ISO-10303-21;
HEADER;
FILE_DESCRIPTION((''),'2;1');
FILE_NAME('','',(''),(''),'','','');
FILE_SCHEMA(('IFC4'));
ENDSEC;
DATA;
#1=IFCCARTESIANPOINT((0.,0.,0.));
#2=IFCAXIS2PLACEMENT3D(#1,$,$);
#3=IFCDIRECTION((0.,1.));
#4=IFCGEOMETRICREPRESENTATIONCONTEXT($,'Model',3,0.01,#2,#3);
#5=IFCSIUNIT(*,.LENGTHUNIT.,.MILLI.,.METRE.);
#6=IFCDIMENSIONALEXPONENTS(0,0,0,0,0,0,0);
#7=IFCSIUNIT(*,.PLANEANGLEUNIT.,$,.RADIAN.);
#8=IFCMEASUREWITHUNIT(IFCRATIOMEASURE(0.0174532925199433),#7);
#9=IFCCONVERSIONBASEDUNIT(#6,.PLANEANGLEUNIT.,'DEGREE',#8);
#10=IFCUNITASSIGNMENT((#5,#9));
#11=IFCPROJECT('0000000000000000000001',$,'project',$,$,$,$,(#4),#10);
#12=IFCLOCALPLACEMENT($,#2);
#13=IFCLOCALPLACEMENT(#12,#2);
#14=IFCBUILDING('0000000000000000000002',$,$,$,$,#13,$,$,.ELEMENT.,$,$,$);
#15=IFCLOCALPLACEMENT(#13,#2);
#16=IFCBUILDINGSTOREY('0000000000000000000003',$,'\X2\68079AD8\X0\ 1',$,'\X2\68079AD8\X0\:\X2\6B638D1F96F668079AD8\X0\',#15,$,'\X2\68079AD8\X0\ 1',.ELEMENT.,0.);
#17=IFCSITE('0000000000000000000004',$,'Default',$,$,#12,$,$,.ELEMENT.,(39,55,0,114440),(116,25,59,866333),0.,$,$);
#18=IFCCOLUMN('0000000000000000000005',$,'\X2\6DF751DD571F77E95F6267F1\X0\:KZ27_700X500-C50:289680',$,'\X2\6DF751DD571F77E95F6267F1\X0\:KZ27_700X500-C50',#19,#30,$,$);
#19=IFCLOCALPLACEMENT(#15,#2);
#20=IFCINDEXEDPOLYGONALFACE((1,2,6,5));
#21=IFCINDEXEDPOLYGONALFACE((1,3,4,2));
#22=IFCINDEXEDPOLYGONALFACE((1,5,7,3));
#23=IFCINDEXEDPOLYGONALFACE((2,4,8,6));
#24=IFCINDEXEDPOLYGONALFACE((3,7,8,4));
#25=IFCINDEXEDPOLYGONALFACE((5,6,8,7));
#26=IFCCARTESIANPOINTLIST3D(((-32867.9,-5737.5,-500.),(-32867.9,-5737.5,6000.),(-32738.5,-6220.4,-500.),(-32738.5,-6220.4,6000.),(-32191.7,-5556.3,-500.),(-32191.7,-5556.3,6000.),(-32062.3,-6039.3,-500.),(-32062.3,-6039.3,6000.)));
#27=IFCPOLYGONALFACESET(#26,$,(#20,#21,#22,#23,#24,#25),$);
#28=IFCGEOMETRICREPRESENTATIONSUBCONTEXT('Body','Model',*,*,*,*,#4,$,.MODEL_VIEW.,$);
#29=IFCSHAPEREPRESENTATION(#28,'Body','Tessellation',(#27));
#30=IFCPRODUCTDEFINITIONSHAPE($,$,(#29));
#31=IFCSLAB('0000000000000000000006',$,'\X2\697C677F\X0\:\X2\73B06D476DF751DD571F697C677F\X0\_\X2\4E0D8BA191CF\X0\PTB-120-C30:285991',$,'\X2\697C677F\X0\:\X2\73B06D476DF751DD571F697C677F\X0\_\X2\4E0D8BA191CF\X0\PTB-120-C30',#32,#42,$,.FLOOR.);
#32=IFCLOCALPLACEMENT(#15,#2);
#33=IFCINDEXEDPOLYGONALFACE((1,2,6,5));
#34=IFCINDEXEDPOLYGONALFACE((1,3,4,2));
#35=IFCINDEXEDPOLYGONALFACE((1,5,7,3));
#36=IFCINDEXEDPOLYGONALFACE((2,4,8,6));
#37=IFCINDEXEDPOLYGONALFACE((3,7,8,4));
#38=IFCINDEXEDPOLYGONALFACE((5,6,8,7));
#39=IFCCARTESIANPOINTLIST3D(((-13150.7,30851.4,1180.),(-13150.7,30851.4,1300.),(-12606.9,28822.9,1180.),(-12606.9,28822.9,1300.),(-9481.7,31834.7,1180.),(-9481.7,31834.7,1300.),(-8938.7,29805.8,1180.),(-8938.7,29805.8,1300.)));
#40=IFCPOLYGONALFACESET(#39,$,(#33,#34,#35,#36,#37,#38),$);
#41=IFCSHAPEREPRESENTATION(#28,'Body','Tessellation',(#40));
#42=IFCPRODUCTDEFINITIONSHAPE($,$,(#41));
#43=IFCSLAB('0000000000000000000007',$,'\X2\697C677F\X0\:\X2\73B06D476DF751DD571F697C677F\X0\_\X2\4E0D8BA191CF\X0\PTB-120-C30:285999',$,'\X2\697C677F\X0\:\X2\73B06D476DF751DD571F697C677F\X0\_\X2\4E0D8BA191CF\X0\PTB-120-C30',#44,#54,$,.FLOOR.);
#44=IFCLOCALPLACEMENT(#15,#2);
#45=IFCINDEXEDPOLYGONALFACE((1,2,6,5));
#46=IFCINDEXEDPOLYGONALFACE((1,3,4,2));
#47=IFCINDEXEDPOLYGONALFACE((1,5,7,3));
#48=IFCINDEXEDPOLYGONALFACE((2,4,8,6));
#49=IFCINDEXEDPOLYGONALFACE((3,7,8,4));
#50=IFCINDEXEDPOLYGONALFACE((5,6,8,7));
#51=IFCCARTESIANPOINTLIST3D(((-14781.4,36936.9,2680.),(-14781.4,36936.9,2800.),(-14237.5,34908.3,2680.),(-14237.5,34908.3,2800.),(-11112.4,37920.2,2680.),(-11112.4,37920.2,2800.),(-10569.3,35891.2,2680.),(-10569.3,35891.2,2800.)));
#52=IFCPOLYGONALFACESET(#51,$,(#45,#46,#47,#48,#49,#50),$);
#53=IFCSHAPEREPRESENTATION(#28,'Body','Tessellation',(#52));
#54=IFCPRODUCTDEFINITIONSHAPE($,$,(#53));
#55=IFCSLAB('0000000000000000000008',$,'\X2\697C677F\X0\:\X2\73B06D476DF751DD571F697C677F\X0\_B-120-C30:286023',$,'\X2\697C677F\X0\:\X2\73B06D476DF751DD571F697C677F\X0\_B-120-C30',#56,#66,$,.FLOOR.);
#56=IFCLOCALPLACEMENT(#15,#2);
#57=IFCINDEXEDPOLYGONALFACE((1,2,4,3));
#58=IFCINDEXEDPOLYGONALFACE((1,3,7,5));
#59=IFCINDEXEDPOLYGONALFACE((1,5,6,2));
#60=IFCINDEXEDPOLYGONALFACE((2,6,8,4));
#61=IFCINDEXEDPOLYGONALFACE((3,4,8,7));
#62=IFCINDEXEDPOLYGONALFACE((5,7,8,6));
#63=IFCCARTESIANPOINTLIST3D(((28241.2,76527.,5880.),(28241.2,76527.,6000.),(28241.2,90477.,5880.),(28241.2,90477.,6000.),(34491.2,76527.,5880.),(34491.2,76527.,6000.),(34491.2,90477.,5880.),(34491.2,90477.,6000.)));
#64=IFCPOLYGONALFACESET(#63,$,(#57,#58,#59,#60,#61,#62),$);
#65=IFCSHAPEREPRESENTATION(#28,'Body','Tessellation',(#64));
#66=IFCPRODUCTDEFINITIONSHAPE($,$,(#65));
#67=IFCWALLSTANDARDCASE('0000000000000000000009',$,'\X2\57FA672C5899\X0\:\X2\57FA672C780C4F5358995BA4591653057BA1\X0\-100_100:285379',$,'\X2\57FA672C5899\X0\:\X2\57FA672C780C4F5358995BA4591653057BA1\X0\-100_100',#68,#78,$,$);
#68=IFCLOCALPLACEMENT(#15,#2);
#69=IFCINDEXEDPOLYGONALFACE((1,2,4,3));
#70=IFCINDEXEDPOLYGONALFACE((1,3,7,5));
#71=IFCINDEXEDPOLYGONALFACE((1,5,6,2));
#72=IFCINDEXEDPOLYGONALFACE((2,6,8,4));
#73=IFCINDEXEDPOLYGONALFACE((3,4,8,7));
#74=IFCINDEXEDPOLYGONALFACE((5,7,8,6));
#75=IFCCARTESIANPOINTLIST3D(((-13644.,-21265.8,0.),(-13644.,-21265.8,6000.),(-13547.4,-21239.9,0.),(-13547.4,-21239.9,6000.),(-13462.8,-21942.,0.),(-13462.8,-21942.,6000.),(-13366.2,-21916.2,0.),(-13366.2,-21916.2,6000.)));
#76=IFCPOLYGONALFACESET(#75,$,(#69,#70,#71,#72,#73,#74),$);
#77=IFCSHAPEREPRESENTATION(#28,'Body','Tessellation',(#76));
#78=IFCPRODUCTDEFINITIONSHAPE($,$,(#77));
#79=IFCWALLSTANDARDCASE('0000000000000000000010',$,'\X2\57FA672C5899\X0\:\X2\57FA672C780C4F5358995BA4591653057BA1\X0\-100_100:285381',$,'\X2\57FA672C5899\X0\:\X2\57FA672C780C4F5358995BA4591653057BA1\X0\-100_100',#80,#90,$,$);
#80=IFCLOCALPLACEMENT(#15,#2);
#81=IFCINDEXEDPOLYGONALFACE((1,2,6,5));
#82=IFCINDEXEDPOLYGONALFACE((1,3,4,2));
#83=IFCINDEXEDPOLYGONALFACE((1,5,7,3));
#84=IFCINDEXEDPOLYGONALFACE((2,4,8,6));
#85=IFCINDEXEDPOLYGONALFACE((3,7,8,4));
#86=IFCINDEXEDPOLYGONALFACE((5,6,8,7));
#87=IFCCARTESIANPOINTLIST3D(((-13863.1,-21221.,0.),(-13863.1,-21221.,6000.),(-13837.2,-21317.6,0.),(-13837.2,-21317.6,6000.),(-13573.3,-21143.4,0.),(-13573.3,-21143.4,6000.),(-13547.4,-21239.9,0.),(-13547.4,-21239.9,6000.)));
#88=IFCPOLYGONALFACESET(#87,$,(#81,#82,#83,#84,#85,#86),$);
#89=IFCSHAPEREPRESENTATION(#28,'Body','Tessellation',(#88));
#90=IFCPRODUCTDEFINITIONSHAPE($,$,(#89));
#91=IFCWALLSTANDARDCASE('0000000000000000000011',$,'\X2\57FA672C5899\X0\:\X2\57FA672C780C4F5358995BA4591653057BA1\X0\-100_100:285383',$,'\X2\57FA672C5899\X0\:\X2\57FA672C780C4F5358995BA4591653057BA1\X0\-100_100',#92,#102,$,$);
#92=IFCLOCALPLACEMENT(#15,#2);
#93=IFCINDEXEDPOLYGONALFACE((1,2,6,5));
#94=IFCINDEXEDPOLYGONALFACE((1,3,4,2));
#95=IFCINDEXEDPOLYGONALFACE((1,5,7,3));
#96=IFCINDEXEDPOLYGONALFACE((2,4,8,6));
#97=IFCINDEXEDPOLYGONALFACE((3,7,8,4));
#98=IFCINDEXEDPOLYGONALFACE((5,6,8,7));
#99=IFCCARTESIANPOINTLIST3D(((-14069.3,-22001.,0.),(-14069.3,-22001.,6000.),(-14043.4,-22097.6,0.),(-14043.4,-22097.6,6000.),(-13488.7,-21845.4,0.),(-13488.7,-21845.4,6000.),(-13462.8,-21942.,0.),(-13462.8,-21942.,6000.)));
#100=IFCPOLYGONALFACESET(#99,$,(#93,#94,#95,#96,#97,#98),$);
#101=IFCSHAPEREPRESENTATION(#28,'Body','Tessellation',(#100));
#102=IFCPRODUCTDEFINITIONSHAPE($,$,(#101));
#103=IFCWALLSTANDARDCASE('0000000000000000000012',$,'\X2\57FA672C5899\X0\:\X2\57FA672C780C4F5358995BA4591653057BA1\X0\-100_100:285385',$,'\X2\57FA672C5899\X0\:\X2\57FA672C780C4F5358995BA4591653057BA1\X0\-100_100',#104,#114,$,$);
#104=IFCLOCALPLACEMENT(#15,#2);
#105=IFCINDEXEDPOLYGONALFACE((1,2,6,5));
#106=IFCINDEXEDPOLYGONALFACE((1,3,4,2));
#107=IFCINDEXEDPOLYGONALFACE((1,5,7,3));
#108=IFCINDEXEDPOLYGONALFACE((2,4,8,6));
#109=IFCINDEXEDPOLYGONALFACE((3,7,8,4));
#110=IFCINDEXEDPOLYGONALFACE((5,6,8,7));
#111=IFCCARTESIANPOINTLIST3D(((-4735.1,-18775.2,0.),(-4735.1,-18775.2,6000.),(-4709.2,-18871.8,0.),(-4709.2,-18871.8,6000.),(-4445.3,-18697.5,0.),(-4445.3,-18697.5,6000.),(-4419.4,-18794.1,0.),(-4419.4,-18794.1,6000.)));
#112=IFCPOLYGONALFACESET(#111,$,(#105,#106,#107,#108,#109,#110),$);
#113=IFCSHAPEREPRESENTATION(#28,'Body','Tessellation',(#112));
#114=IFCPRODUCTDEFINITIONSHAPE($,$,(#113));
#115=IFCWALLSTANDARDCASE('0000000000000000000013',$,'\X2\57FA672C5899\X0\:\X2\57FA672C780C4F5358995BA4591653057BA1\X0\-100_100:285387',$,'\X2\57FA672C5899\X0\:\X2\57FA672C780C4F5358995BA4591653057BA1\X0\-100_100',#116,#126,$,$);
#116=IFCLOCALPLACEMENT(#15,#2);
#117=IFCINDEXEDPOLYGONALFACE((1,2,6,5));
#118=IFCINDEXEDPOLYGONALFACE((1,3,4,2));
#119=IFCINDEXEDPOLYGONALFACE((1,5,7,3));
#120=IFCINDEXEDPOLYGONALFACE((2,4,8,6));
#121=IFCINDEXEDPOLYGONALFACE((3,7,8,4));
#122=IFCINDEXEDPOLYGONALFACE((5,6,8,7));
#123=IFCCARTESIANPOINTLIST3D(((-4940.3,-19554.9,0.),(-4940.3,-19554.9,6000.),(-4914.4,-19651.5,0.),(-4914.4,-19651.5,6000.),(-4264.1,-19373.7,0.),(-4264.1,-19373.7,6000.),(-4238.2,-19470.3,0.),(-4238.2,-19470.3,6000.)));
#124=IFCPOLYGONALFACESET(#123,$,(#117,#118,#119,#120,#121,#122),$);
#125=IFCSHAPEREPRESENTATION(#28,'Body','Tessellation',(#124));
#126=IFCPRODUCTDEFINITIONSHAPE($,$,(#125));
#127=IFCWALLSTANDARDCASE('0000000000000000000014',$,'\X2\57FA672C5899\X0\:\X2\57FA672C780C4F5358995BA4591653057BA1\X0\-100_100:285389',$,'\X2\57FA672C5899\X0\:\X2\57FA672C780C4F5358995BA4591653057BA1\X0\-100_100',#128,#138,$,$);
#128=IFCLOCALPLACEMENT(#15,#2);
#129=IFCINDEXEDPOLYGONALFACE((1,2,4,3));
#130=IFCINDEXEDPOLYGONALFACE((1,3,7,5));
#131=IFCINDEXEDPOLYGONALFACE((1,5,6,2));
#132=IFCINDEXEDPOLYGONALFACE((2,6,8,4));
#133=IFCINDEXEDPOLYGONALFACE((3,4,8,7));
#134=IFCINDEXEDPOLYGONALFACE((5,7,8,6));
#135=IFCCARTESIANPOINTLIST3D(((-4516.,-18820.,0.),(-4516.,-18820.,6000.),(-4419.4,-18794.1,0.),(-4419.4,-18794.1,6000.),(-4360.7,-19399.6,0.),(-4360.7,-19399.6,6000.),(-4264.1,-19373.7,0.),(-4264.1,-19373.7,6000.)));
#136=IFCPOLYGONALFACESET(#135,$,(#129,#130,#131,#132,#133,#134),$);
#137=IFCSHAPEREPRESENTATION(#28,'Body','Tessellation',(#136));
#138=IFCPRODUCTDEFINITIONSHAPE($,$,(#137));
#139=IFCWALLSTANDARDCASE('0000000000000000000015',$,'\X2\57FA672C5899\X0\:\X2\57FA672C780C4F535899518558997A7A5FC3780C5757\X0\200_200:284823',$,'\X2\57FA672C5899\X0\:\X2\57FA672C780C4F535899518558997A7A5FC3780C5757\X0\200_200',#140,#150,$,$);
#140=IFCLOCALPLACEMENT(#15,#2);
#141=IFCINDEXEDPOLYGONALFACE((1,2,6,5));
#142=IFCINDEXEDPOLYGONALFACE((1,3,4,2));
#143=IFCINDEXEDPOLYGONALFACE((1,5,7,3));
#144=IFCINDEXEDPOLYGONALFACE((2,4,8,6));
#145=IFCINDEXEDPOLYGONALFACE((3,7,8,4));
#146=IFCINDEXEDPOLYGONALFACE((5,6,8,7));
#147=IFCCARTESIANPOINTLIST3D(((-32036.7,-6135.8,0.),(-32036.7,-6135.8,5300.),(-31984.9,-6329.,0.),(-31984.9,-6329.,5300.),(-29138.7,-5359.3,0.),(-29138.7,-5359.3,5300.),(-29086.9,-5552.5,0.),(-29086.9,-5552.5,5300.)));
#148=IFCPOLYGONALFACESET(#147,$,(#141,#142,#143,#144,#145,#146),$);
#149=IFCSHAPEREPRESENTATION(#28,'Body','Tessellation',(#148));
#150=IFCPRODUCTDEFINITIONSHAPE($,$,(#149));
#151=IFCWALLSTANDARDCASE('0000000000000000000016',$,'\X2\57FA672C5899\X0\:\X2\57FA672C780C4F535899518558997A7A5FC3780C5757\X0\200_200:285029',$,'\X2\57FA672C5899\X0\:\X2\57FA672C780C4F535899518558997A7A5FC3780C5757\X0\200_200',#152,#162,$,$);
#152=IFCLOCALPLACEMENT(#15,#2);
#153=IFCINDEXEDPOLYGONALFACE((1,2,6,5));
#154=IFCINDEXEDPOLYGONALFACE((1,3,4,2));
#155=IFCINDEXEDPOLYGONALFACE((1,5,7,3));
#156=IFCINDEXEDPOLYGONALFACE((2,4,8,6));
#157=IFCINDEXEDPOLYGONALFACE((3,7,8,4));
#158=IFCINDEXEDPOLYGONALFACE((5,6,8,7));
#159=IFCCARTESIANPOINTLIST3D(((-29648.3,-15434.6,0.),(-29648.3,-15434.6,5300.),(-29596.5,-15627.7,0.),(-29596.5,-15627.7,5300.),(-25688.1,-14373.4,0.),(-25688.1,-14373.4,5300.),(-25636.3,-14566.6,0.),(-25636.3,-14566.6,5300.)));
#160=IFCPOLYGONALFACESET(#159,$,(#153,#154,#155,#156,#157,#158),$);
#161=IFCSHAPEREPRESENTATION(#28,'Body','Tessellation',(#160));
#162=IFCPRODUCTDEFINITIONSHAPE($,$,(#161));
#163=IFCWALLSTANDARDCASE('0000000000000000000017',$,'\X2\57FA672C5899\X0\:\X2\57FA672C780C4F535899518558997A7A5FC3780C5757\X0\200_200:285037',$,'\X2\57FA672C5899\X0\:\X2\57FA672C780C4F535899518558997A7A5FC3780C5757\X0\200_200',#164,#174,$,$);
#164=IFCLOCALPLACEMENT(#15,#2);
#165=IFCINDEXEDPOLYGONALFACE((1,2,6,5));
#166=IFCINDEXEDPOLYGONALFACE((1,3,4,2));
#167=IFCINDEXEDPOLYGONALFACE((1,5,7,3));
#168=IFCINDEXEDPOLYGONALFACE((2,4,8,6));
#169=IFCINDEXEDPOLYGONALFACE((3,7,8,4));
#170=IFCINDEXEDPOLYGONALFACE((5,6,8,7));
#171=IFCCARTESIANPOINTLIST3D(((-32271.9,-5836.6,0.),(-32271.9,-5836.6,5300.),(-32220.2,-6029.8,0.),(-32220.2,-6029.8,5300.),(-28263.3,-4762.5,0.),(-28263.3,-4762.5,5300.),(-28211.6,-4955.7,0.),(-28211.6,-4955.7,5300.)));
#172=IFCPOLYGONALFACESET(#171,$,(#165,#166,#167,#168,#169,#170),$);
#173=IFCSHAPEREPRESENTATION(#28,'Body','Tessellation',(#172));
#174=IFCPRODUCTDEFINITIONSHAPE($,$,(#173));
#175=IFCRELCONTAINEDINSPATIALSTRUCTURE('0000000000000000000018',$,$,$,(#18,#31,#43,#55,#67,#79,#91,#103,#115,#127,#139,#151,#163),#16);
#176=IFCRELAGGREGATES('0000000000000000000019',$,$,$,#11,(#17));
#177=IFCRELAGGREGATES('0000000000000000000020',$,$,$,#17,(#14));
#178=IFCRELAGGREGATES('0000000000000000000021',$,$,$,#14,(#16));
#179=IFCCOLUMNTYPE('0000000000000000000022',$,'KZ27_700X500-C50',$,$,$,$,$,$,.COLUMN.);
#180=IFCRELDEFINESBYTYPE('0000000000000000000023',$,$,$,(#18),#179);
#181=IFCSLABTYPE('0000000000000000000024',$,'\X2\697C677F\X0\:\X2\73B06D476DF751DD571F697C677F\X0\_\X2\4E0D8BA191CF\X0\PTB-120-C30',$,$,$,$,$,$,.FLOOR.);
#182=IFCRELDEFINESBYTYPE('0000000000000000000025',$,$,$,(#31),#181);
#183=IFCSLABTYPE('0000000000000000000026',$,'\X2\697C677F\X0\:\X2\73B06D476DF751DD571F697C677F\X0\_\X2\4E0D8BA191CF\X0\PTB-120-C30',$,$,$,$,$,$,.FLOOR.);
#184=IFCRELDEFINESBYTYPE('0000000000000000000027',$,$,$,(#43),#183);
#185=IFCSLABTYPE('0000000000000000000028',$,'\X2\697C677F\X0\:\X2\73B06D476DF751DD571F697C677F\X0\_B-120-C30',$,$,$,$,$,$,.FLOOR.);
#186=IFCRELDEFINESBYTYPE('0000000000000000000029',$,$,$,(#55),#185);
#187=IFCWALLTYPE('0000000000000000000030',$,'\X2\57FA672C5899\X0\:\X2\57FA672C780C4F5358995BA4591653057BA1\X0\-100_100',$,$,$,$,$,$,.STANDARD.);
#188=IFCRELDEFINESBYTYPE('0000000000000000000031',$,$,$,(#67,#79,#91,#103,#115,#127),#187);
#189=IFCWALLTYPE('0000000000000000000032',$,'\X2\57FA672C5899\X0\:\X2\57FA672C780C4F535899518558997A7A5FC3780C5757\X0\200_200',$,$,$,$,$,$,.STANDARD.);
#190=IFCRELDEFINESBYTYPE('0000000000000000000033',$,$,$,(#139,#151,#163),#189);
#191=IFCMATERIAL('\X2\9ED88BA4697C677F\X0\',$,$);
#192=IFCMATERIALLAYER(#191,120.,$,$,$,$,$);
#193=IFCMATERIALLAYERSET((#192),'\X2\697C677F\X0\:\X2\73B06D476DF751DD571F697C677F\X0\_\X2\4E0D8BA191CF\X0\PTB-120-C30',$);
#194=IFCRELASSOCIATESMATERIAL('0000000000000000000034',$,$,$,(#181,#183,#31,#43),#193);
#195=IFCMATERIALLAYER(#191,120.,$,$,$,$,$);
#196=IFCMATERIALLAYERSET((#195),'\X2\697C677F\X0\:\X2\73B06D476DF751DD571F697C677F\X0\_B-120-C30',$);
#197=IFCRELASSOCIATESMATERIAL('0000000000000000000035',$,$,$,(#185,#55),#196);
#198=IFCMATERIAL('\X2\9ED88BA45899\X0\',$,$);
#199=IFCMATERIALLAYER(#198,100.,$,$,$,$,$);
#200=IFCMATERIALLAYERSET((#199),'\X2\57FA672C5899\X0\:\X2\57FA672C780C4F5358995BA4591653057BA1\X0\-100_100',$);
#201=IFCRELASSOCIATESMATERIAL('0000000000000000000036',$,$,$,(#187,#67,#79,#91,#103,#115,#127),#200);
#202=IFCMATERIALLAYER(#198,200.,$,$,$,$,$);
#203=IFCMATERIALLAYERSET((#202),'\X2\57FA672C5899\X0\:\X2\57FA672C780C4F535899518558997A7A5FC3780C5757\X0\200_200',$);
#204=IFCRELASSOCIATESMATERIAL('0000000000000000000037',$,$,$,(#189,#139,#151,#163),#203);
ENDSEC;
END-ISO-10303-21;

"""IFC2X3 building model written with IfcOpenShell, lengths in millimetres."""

from ifc_helpers import new_model, entity, si_unit, converted_unit, direction, frame, frame_2d, origin, origin_2d_with_axis, place, context, subcontext, project, spatial, polyline, rectangle, outline, extrude, source, transform, mapped, material, layer, layer_set, layer_usage, type_object, type_shapes, element, save


model = new_model("IFC2X3")

# Units and contexts
model_context = context("Model", 3, precision=0.01, world=origin(), true_north=direction((0.0, 1.0)))
body_context = subcontext(model_context, "Body", "Model", "MODEL_VIEW")
ifc_project = project(units=[si_unit("LENGTHUNIT", "METRE", prefix="MILLI"), converted_unit("PLANEANGLEUNIT", "DEGREE", entity("IfcRatioMeasure", 0.0174532925199433), si_unit("PLANEANGLEUNIT", "RADIAN"), dimensions=[0, 0, 0, 0, 0, 0, 0])], contexts=[model_context])

# Site, building, storey
site_placement = place(None, origin())
site = spatial("IfcSite", under=ifc_project, at=site_placement, Name="Default", CompositionType="ELEMENT", RefLatitude=(39, 55, 0, 114440), RefLongitude=(116, 25, 59, 866333), RefElevation=0.0)
building_placement = place(site_placement, origin())
building = spatial("IfcBuilding", under=site, at=building_placement, CompositionType="ELEMENT")
storey_placement = place(building_placement, origin())
storey = spatial("IfcBuildingStorey", under=building, at=storey_placement, Name="标高 1", ObjectType="标高:正负零标高", LongName="标高 1", CompositionType="ELEMENT", Elevation=0.0)

# Column
column_type_1 = type_object("IfcColumnType", Name="KZ27_700X500-C50", PredefinedType="COLUMN")
shared_shape_1 = source(origin(), body_context, "Body", "SweptSolid", [
    extrude(rectangle(XDim=500.0, YDim=700.0, at=origin_2d_with_axis()), frame((0.0, 0.0, -500.0), z_axis=(0.0, 0.0, 1.0), x_axis=(0.0, -1.0, 0.0)), (0.0, 0.0, 1.0), 6500.0),
])
type_shapes(column_type_1, [shared_shape_1])
column_1_placement = place(building_placement, frame((-32465.1, -5888.4, 0.0), z_axis=(0.0, 0.0, 1.0), x_axis=(0.965926, 0.258819, 0.0)))
element("IfcColumn", 1, at=column_1_placement, inside=storey, type_object=column_type_1, Name="混凝土矩形柱:KZ27_700X500-C50:289680", ObjectType="混凝土矩形柱:KZ27_700X500-C50", context=body_context, shape_type="MappedRepresentation", body=[
    mapped(shared_shape_1, transform((0.0, 0.0, 0.0), scale=1.0)),
])

# Slabs
ifc_material_1 = material(Name="默认楼板")
ifc_layer_1 = layer(ifc_material_1, 120.0)
ifc_layer_set_1 = layer_set([ifc_layer_1], Name="楼板:现浇混凝土楼板_不计量PTB-120-C30")
ifc_layer_usage_1 = layer_usage(ifc_layer_set_1, "AXIS3", "POSITIVE", 0.0)
slab_type_1 = type_object("IfcSlabType", Name="楼板:现浇混凝土楼板_不计量PTB-120-C30", PredefinedType="FLOOR", material=ifc_layer_set_1)
slab_1_placement = place(building_placement, origin())
element("IfcSlab", 2, at=slab_1_placement, inside=storey, type_object=slab_type_1, material=ifc_layer_usage_1, Name="楼板:现浇混凝土楼板_不计量PTB-120-C30:285991", ObjectType="楼板:现浇混凝土楼板_不计量PTB-120-C30", PredefinedType="FLOOR", context=body_context, shape_type="SweptSolid", body=[
    extrude(outline(polyline([(-1899.1, -1050.1), (1899.4, -1050.1), (1898.7, 1050.3), (-1899.0, 1050.0), (-1899.1, -1050.1)])), frame((-11044.5, 30328.7, 1300.0), z_axis=(0.0, 0.0, -1.0), x_axis=(0.96591, 0.258877, 0.0)), (0.0, 0.0, 1.0), 120.0),
])
ifc_layer_usage_2 = layer_usage(ifc_layer_set_1, "AXIS3", "POSITIVE", 0.0)
slab_type_2 = type_object("IfcSlabType", Name="楼板:现浇混凝土楼板_不计量PTB-120-C30", PredefinedType="FLOOR", material=ifc_layer_set_1)
slab_2_placement = place(building_placement, origin())
element("IfcSlab", 3, at=slab_2_placement, inside=storey, type_object=slab_type_2, material=ifc_layer_usage_2, Name="楼板:现浇混凝土楼板_不计量PTB-120-C30:285999", ObjectType="楼板:现浇混凝土楼板_不计量PTB-120-C30", PredefinedType="FLOOR", context=body_context, shape_type="SweptSolid", body=[
    extrude(outline(polyline([(-1899.1, -1050.1), (1899.4, -1050.1), (1898.7, 1050.3), (-1899.0, 1050.0), (-1899.1, -1050.1)])), frame((-12675.1, 36414.2, 2800.0), z_axis=(0.0, 0.0, -1.0), x_axis=(0.96591, 0.258877, 0.0)), (0.0, 0.0, 1.0), 120.0),
])
ifc_layer_2 = layer(ifc_material_1, 120.0)
ifc_layer_set_2 = layer_set([ifc_layer_2], Name="楼板:现浇混凝土楼板_B-120-C30")
ifc_layer_usage_3 = layer_usage(ifc_layer_set_2, "AXIS3", "POSITIVE", 0.0)
slab_type_3 = type_object("IfcSlabType", Name="楼板:现浇混凝土楼板_B-120-C30", PredefinedType="FLOOR", material=ifc_layer_set_2)
slab_3_placement = place(building_placement, origin())
element("IfcSlab", 4, at=slab_3_placement, inside=storey, type_object=slab_type_3, material=ifc_layer_usage_3, Name="楼板:现浇混凝土楼板_B-120-C30:286023", ObjectType="楼板:现浇混凝土楼板_B-120-C30", PredefinedType="FLOOR", context=body_context, shape_type="SweptSolid", body=[
    extrude(outline(polyline([(-6975.0, -3125.0), (6975.0, -3125.0), (6975.0, 3125.0), (-6975.0, 3125.0), (-6975.0, -3125.0)])), frame((31366.2, 83502.0, 6000.0), z_axis=(0.0, 0.0, -1.0), x_axis=(0.0, 1.0, 0.0)), (0.0, 0.0, 1.0), 120.0),
])

# Walls
ifc_material_2 = material(Name="默认墙")
ifc_layer_3 = layer(ifc_material_2, 100.0)
ifc_layer_set_3 = layer_set([ifc_layer_3], Name="基本墙:基本砌体墙室外包管-100_100")
ifc_layer_usage_4 = layer_usage(ifc_layer_set_3, "AXIS2", "NEGATIVE", 50.0)
wall_type_1 = type_object("IfcWallType", Name="基本墙:基本砌体墙室外包管-100_100", PredefinedType="STANDARD", material=ifc_layer_set_3)
wall_1_placement = place(building_placement, frame((-13414.5, -21929.1, 0.0), z_axis=(0.0, 0.0, 1.0), x_axis=(-0.258819, 0.965926, 0.0)))
element("IfcWallStandardCase", 5, at=wall_1_placement, inside=storey, type_object=wall_type_1, material=ifc_layer_usage_4, Name="基本墙:基本砌体墙室外包管-100_100:285379", ObjectType="基本墙:基本砌体墙室外包管-100_100", context=body_context, shape_type="SweptSolid", body=[
    extrude(rectangle(XDim=700.1, YDim=100.0, at=frame_2d((350.0, 0.0), x_axis=(-1.0, 0.0))), origin(), (0.0, 0.0, 1.0), 6000.0),
])
ifc_layer_usage_5 = layer_usage(ifc_layer_set_3, "AXIS2", "NEGATIVE", 50.0)
wall_2_placement = place(building_placement, frame((-13560.4, -21191.6, 0.0), z_axis=(0.0, 0.0, 1.0), x_axis=(-0.965926, -0.258819, 0.0)))
element("IfcWallStandardCase", 6, at=wall_2_placement, inside=storey, type_object=wall_type_1, material=ifc_layer_usage_5, Name="基本墙:基本砌体墙室外包管-100_100:285381", ObjectType="基本墙:基本砌体墙室外包管-100_100", context=body_context, shape_type="SweptSolid", body=[
    extrude(rectangle(XDim=300.0, YDim=100.0, at=frame_2d((150.0, 0.0), x_axis=(-1.0, 0.0))), origin(), (0.0, 0.0, 1.0), 6000.0),
])
ifc_layer_usage_6 = layer_usage(ifc_layer_set_3, "AXIS2", "NEGATIVE", 50.0)
wall_3_placement = place(building_placement, frame((-14056.3, -22049.3, 0.0), z_axis=(0.0, 0.0, 1.0), x_axis=(0.965926, 0.258819, 0.0)))
element("IfcWallStandardCase", 7, at=wall_3_placement, inside=storey, type_object=wall_type_1, material=ifc_layer_usage_6, Name="基本墙:基本砌体墙室外包管-100_100:285383", ObjectType="基本墙:基本砌体墙室外包管-100_100", context=body_context, shape_type="SweptSolid", body=[
    extrude(rectangle(XDim=601.0, YDim=100.0, at=frame_2d((300.5, 0.0), x_axis=(-1.0, 0.0))), origin(), (0.0, 0.0, 1.0), 6000.0),
])
ifc_layer_usage_7 = layer_usage(ifc_layer_set_3, "AXIS2", "NEGATIVE", 50.0)
wall_4_placement = place(building_placement, frame((-4432.4, -18745.8, 0.0), z_axis=(0.0, 0.0, 1.0), x_axis=(-0.965926, -0.258819, 0.0)))
element("IfcWallStandardCase", 8, at=wall_4_placement, inside=storey, type_object=wall_type_1, material=ifc_layer_usage_7, Name="基本墙:基本砌体墙室外包管-100_100:285385", ObjectType="基本墙:基本砌体墙室外包管-100_100", context=body_context, shape_type="SweptSolid", body=[
    extrude(rectangle(XDim=300.0, YDim=100.0, at=frame_2d((150.0, 0.0), x_axis=(-1.0, 0.0))), origin(), (0.0, 0.0, 1.0), 6000.0),
])
ifc_layer_usage_8 = layer_usage(ifc_layer_set_3, "AXIS2", "NEGATIVE", 50.0)
wall_5_placement = place(building_placement, frame((-4927.3, -19603.2, 0.0), z_axis=(0.0, 0.0, 1.0), x_axis=(0.965926, 0.258819, 0.0)))
element("IfcWallStandardCase", 9, at=wall_5_placement, inside=storey, type_object=wall_type_1, material=ifc_layer_usage_8, Name="基本墙:基本砌体墙室外包管-100_100:285387", ObjectType="基本墙:基本砌体墙室外包管-100_100", context=body_context, shape_type="SweptSolid", body=[
    extrude(rectangle(XDim=700.0, YDim=100.0, at=frame_2d((350.0, 0.0), x_axis=(-1.0, 0.0))), origin(), (0.0, 0.0, 1.0), 6000.0),
])
ifc_layer_usage_9 = layer_usage(ifc_layer_set_3, "AXIS2", "NEGATIVE", 50.0)
wall_6_placement = place(building_placement, frame((-4312.4, -19386.7, 0.0), z_axis=(0.0, 0.0, 1.0), x_axis=(-0.258819, 0.965926, 0.0)))
element("IfcWallStandardCase", 10, at=wall_6_placement, inside=storey, type_object=wall_type_1, material=ifc_layer_usage_9, Name="基本墙:基本砌体墙室外包管-100_100:285389", ObjectType="基本墙:基本砌体墙室外包管-100_100", context=body_context, shape_type="SweptSolid", body=[
    extrude(rectangle(XDim=600.1, YDim=100.0, at=frame_2d((300.0, 0.0), x_axis=(-1.0, 0.0))), origin(), (0.0, 0.0, 1.0), 6000.0),
])
ifc_layer_4 = layer(ifc_material_2, 200.0)
ifc_layer_set_4 = layer_set([ifc_layer_4], Name="基本墙:基本砌体墙内墙空心砌块200_200")
ifc_layer_usage_10 = layer_usage(ifc_layer_set_4, "AXIS2", "NEGATIVE", 100.0)
wall_type_2 = type_object("IfcWallType", Name="基本墙:基本砌体墙内墙空心砌块200_200", PredefinedType="STANDARD", material=ifc_layer_set_4)
wall_7_placement = place(building_placement, frame((-32010.8, -6232.4, 0.0), z_axis=(0.0, 0.0, 1.0), x_axis=(0.965926, 0.258819, 0.0)))
element("IfcWallStandardCase", 11, at=wall_7_placement, inside=storey, type_object=wall_type_2, material=ifc_layer_usage_10, Name="基本墙:基本砌体墙内墙空心砌块200_200:284823", ObjectType="基本墙:基本砌体墙内墙空心砌块200_200", context=body_context, shape_type="SweptSolid", body=[
    extrude(rectangle(XDim=3000.2, YDim=200.0, at=frame_2d((1500.1, 0.0), x_axis=(-1.0, 0.0))), origin(), (0.0, 0.0, 1.0), 5300.0),
])
ifc_layer_usage_11 = layer_usage(ifc_layer_set_4, "AXIS2", "NEGATIVE", 100.0)
wall_8_placement = place(building_placement, frame((-29622.4, -15531.2, 0.0), z_axis=(0.0, 0.0, 1.0), x_axis=(0.965926, 0.258819, 0.0)))
element("IfcWallStandardCase", 12, at=wall_8_placement, inside=storey, type_object=wall_type_2, material=ifc_layer_usage_11, Name="基本墙:基本砌体墙内墙空心砌块200_200:285029", ObjectType="基本墙:基本砌体墙内墙空心砌块200_200", context=body_context, shape_type="SweptSolid", body=[
    extrude(rectangle(XDim=4099.9, YDim=200.0, at=frame_2d((2050.0, 0.0), x_axis=(-1.0, 0.0))), origin(), (0.0, 0.0, 1.0), 5300.0),
])
ifc_layer_usage_12 = layer_usage(ifc_layer_set_4, "AXIS2", "NEGATIVE", 100.0)
wall_9_placement = place(building_placement, frame((-28237.4, -4859.1, 0.0), z_axis=(0.0, 0.0, 1.0), x_axis=(-0.965926, -0.258819, 0.0)))
element("IfcWallStandardCase", 13, at=wall_9_placement, inside=storey, type_object=wall_type_2, material=ifc_layer_usage_12, Name="基本墙:基本砌体墙内墙空心砌块200_200:285037", ObjectType="基本墙:基本砌体墙内墙空心砌块200_200", context=body_context, shape_type="SweptSolid", body=[
    extrude(rectangle(XDim=4150.0, YDim=200.0, at=frame_2d((2075.0, 0.0), x_axis=(-1.0, 0.0))), origin(), (0.0, 0.0, 1.0), 5300.0),
])

save(model, "model.ifc")
